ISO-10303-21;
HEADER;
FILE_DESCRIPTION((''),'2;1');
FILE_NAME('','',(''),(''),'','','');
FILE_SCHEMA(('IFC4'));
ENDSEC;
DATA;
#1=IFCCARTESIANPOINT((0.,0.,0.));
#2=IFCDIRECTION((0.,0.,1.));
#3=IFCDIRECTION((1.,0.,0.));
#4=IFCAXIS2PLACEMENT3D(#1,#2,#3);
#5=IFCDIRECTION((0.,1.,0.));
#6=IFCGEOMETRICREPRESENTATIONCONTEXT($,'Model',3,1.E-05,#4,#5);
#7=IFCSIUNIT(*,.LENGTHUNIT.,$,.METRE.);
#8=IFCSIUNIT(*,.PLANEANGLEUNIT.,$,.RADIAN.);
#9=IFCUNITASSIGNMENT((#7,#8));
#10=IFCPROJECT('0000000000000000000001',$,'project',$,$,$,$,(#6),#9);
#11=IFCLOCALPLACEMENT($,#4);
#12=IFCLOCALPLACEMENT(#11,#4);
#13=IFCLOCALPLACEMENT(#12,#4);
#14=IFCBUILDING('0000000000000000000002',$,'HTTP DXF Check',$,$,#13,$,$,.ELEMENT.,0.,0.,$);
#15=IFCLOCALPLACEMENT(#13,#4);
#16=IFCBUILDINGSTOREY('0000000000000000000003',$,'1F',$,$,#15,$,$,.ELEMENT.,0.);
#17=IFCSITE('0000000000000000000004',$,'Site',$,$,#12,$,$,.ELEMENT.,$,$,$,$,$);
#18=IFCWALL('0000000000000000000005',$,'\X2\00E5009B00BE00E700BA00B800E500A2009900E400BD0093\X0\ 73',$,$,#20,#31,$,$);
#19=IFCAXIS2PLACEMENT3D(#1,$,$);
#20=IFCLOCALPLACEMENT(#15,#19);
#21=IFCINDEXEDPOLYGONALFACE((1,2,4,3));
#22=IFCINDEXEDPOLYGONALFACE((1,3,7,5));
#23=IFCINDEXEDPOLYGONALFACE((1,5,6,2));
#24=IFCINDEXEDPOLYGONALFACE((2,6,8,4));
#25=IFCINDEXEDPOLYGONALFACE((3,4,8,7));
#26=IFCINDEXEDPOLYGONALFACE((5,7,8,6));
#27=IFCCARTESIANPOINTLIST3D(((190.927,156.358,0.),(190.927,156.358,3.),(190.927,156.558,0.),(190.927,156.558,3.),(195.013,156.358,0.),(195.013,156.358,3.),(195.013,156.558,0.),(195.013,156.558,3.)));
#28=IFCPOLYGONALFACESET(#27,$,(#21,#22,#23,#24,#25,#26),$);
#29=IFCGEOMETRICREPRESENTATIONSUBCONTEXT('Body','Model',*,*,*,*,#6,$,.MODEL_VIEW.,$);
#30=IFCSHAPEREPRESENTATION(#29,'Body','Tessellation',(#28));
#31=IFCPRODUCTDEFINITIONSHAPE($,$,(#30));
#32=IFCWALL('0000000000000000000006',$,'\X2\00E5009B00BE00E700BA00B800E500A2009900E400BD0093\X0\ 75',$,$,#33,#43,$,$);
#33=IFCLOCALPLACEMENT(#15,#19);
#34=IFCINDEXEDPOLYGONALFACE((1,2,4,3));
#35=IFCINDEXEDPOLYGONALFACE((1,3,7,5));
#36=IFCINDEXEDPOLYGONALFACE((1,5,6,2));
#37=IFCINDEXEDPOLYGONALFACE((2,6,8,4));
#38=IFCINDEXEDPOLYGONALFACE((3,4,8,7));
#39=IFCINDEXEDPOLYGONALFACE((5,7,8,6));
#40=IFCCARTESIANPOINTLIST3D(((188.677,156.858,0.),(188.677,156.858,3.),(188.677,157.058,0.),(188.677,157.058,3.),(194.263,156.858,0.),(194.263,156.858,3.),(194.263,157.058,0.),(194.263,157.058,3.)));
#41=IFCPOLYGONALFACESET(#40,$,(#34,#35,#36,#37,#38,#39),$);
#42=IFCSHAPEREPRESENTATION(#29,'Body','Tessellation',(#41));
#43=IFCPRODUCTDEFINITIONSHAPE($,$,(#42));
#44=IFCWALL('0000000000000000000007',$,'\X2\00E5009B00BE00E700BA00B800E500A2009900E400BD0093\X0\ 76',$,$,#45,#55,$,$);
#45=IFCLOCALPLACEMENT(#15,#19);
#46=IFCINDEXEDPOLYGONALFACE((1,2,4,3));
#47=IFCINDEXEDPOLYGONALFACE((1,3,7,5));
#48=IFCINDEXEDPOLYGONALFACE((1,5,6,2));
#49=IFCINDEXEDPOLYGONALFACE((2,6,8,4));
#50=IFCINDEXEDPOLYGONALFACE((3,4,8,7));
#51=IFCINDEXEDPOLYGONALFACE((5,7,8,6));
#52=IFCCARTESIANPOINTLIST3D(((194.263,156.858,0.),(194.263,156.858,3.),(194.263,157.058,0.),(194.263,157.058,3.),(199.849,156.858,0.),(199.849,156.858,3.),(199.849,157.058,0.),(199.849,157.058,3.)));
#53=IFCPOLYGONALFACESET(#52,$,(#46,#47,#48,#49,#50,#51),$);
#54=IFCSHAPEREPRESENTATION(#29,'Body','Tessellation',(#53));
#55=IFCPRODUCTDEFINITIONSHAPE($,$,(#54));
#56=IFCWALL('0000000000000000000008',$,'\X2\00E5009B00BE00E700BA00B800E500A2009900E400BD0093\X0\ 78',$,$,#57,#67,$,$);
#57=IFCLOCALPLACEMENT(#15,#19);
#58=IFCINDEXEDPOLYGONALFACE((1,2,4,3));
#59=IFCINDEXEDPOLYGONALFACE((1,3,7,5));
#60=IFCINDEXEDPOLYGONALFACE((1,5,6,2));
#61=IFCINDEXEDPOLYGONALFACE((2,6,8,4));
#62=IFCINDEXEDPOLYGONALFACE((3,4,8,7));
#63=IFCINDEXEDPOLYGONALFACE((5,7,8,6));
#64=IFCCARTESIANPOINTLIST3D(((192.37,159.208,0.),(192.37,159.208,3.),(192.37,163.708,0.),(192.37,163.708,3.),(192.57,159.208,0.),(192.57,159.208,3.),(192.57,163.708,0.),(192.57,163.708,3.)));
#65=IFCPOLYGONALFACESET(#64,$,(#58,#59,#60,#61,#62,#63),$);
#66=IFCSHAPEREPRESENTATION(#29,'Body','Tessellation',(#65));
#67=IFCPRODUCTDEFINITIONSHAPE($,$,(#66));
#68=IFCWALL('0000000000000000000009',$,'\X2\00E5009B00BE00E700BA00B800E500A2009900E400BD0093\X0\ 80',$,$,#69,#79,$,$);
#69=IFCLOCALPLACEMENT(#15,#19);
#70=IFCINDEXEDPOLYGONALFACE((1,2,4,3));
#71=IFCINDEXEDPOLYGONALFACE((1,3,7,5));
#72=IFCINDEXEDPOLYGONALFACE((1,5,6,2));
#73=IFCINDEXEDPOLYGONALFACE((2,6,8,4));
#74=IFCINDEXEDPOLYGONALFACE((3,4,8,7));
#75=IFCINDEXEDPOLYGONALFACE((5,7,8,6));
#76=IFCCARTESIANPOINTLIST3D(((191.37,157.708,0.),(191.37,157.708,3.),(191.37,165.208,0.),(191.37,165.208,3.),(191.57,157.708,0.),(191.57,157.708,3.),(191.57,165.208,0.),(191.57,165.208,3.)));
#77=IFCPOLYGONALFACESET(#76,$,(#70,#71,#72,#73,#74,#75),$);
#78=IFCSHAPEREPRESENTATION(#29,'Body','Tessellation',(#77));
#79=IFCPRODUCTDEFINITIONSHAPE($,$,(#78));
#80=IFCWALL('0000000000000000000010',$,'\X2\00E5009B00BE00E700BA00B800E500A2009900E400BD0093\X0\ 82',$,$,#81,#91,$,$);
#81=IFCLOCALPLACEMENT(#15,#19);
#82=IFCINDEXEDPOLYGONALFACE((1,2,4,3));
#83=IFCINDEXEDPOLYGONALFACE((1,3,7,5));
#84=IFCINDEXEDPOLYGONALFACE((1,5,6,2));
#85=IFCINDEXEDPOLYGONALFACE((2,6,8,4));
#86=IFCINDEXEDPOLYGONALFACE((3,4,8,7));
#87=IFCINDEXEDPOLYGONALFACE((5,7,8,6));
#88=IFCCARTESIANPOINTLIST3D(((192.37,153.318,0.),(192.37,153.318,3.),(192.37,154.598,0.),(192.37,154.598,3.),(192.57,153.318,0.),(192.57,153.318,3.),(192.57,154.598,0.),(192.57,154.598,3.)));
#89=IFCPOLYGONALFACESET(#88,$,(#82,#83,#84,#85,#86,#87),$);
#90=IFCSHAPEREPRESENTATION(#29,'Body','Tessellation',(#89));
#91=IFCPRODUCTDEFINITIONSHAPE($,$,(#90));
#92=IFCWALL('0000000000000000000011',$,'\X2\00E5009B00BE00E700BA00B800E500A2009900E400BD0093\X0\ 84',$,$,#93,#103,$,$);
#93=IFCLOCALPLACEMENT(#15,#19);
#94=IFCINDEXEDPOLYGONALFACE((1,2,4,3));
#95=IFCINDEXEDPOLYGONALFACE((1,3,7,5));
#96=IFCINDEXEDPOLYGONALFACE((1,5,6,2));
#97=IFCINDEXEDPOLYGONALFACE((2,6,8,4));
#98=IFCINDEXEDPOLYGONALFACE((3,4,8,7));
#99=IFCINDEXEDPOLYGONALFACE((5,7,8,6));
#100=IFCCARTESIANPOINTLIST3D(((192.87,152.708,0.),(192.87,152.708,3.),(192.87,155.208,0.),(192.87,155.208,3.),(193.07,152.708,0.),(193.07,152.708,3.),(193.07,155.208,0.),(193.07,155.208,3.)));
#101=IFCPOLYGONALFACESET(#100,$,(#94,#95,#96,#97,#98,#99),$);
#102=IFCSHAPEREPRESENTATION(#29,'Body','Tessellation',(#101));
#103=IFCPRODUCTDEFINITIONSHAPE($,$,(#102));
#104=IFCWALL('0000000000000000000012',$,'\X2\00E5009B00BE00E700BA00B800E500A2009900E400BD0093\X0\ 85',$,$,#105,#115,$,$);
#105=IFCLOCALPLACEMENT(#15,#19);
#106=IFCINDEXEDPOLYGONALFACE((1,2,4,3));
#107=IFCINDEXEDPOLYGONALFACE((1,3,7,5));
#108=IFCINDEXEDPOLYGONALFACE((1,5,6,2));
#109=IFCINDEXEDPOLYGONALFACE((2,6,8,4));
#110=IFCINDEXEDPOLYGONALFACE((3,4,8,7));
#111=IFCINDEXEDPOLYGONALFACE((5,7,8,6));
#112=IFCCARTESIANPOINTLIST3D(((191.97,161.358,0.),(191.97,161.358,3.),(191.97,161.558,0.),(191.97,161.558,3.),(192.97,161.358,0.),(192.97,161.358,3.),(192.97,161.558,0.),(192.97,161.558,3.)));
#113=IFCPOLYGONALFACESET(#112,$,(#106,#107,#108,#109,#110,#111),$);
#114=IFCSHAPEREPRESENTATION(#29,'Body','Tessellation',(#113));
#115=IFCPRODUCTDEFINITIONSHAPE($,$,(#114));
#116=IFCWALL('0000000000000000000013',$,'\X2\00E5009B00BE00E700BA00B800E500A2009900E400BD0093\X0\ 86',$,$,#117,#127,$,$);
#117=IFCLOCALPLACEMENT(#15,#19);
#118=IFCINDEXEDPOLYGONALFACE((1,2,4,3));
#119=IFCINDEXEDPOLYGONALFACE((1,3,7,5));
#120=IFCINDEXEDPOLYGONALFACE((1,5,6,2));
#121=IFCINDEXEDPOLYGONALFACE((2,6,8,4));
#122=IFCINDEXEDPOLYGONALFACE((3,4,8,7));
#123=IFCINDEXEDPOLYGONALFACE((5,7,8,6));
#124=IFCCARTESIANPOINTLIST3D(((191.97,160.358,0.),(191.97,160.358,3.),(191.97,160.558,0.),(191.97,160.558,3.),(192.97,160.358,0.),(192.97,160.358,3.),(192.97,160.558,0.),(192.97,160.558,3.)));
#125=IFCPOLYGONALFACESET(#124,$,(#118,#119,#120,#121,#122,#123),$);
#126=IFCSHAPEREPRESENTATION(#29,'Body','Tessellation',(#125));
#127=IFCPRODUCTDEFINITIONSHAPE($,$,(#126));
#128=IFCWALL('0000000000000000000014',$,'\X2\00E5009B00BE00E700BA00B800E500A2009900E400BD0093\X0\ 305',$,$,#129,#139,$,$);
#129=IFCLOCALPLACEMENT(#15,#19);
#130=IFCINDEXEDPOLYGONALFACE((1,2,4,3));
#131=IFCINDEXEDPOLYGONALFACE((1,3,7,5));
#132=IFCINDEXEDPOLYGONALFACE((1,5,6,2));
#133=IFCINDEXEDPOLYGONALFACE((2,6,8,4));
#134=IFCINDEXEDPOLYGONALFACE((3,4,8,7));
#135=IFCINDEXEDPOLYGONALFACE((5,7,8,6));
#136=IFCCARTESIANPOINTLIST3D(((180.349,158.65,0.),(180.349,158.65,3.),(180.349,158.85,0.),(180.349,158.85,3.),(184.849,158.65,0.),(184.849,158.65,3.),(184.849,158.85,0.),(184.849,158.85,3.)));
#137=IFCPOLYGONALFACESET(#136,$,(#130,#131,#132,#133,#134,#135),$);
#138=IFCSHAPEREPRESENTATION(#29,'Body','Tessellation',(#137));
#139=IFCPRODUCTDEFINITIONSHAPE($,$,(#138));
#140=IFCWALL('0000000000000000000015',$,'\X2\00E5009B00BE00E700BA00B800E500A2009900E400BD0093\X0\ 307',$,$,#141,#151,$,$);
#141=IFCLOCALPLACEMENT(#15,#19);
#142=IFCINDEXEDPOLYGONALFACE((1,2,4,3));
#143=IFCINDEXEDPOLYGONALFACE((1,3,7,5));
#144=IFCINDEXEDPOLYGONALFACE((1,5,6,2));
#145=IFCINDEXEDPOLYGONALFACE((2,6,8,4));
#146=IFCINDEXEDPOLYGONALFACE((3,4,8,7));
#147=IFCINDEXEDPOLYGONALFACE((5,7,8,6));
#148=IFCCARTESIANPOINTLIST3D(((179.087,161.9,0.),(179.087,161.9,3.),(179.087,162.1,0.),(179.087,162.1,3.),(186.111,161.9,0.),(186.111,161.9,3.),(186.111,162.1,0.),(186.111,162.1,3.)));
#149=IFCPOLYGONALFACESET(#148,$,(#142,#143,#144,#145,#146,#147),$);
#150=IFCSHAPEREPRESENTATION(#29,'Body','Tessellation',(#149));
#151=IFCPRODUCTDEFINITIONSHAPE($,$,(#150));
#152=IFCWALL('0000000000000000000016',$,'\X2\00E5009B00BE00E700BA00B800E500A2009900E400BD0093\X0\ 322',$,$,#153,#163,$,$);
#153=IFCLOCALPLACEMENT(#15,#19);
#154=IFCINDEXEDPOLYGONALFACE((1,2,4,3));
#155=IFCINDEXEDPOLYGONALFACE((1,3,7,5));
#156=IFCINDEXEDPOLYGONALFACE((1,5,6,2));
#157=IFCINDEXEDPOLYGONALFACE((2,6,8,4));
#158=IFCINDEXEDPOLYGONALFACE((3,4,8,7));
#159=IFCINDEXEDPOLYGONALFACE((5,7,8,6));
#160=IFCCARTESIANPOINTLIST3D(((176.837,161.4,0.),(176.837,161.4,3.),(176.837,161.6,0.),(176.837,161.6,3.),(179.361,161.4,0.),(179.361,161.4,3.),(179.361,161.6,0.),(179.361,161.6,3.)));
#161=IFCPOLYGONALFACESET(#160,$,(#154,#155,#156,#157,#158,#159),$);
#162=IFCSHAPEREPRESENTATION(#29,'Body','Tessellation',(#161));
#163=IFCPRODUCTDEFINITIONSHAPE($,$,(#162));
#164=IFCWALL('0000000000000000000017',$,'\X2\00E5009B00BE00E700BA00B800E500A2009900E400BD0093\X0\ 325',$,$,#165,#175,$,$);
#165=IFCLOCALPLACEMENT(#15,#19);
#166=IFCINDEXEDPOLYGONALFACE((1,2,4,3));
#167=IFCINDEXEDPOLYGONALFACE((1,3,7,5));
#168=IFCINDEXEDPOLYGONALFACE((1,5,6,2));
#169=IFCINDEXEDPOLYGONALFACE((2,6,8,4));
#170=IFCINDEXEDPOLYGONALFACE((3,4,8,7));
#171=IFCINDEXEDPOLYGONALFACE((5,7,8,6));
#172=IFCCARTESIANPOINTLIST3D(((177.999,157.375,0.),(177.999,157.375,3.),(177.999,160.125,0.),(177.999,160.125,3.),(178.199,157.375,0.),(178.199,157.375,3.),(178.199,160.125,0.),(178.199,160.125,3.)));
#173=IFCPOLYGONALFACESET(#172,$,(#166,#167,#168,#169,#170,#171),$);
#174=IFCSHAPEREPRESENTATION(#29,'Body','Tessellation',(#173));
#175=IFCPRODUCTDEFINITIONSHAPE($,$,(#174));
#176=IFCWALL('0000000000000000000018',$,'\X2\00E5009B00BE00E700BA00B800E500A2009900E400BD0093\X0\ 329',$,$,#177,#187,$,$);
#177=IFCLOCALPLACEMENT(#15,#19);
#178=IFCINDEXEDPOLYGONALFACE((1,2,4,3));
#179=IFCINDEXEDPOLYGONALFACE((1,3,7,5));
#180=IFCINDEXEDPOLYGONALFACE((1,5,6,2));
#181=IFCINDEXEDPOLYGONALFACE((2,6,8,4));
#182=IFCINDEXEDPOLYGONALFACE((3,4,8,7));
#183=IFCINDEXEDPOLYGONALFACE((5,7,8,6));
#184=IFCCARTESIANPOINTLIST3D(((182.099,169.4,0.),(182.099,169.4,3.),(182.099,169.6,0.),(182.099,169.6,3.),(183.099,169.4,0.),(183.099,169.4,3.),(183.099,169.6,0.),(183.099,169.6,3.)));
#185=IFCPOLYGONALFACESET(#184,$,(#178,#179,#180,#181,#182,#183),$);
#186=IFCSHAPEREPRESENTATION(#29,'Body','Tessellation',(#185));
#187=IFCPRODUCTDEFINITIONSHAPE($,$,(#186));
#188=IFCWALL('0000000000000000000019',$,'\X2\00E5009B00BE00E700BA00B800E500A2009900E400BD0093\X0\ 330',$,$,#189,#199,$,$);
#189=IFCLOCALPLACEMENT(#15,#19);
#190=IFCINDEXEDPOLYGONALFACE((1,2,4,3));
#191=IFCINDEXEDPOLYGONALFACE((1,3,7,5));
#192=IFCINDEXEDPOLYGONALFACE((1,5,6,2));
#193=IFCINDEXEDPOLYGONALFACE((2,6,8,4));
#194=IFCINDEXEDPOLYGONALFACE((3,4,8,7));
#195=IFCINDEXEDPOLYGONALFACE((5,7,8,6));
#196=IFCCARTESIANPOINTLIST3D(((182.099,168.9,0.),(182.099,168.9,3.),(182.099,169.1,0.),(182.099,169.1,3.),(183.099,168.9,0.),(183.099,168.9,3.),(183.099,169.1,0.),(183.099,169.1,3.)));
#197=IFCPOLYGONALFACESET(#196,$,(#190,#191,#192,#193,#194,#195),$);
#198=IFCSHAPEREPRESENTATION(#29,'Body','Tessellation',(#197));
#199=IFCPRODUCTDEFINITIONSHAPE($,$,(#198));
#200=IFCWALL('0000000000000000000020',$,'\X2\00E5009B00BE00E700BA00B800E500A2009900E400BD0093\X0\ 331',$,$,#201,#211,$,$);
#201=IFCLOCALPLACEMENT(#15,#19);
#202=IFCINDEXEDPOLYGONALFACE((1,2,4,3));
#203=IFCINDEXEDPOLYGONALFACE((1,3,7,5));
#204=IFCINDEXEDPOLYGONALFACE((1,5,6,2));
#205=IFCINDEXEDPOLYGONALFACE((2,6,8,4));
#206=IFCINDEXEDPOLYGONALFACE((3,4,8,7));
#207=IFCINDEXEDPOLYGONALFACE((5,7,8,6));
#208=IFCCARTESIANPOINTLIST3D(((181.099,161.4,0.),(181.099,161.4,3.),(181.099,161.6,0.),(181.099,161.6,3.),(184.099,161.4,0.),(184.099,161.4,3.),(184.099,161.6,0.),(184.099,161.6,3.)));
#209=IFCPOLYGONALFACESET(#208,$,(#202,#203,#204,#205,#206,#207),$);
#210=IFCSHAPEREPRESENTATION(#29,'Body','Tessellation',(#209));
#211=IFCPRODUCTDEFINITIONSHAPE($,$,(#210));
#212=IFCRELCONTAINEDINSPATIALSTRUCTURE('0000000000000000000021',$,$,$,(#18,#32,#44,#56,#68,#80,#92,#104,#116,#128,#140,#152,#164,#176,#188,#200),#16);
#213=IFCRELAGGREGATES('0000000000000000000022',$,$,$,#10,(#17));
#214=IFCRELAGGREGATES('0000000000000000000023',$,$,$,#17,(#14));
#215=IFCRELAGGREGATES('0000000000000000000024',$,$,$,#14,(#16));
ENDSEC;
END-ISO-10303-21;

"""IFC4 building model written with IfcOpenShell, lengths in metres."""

from ifc_helpers import new_model, si_unit, direction, frame, frame_2d, origin_with_axes, place, context, subcontext, project, spatial, rectangle, extrude, element, save


model = new_model("IFC4")

# Units and contexts
model_context = context("Model", 3, precision=1e-05, world=origin_with_axes(), true_north=direction((0.0, 1.0, 0.0)))
body_context = subcontext(model_context, "Body", "Model", "MODEL_VIEW")
ifc_project = project(units=[si_unit("LENGTHUNIT", "METRE"), si_unit("PLANEANGLEUNIT", "RADIAN")], contexts=[model_context])

# Site, building, storey
placement = place(None, origin_with_axes())
site_placement = place(placement, origin_with_axes())
site = spatial("IfcSite", under=ifc_project, at=site_placement, Name="Site", CompositionType="ELEMENT")
building_placement = place(site_placement, origin_with_axes())
building = spatial("IfcBuilding", under=site, at=building_placement, Name="HTTP DXF Check", CompositionType="ELEMENT", ElevationOfRefHeight=0.0, ElevationOfTerrain=0.0)
storey_placement = place(building_placement, origin_with_axes())
storey = spatial("IfcBuildingStorey", under=building, at=storey_placement, Name="1F", CompositionType="ELEMENT", Elevation=0.0)

# Walls
for number, where, z_axis, x_axis, name in (
    (1, (192.97, 156.458, 0.0), (0.0, 0.0, 1.0), (1.0, 0.0, 0.0), "å\u009b¾çº¸å¢\u0099ä½\u0093 73"),
):
    element("IfcWall", number, at=place(storey_placement, frame(where, z_axis=z_axis, x_axis=x_axis)), inside=storey, Name=name, context=body_context, shape_type="SweptSolid", body=[
        extrude(rectangle(XDim=4.086, YDim=0.2, at=frame_2d((0.0, 0.0), x_axis=(1.0, 0.0, 0.0))), frame((0.0, 0.0, 0.0), z_axis=(0.0, 0.0, 1.0)), (0.0, 0.0, 1.0), 3.0),
    ])
for number, where, z_axis, x_axis, name in (
    (2, (191.47, 156.958, 0.0), (0.0, 0.0, 1.0), (1.0, 0.0, 0.0), "å\u009b¾çº¸å¢\u0099ä½\u0093 75"),
    (3, (197.056, 156.958, 0.0), (0.0, 0.0, 1.0), (-1.0, 0.0, 0.0), "å\u009b¾çº¸å¢\u0099ä½\u0093 76"),
):
    element("IfcWall", number, at=place(storey_placement, frame(where, z_axis=z_axis, x_axis=x_axis)), inside=storey, Name=name, context=body_context, shape_type="SweptSolid", body=[
        extrude(rectangle(XDim=5.586, YDim=0.2, at=frame_2d((0.0, 0.0), x_axis=(1.0, 0.0, 0.0))), frame((0.0, 0.0, 0.0), z_axis=(0.0, 0.0, 1.0)), (0.0, 0.0, 1.0), 3.0),
    ])
wall_1_placement = place(storey_placement, frame((192.47, 161.458, 0.0), z_axis=(0.0, 0.0, 1.0), x_axis=(0.0, -1.0, 0.0)))
element("IfcWall", 4, at=wall_1_placement, inside=storey, Name="å\u009b¾çº¸å¢\u0099ä½\u0093 78", context=body_context, shape_type="SweptSolid", body=[
    extrude(rectangle(XDim=4.5, YDim=0.2, at=frame_2d((0.0, 0.0), x_axis=(1.0, 0.0, 0.0))), frame((0.0, 0.0, 0.0), z_axis=(0.0, 0.0, 1.0)), (0.0, 0.0, 1.0), 3.0),
])
wall_2_placement = place(storey_placement, frame((191.47, 161.458, 0.0), z_axis=(0.0, 0.0, 1.0), x_axis=(0.0, -1.0, 0.0)))
element("IfcWall", 5, at=wall_2_placement, inside=storey, Name="å\u009b¾çº¸å¢\u0099ä½\u0093 80", context=body_context, shape_type="SweptSolid", body=[
    extrude(rectangle(XDim=7.5, YDim=0.2, at=frame_2d((0.0, 0.0), x_axis=(1.0, 0.0, 0.0))), frame((0.0, 0.0, 0.0), z_axis=(0.0, 0.0, 1.0)), (0.0, 0.0, 1.0), 3.0),
])
wall_3_placement = place(storey_placement, frame((192.47, 153.958, 0.0), z_axis=(0.0, 0.0, 1.0), x_axis=(0.0, -1.0, 0.0)))
element("IfcWall", 6, at=wall_3_placement, inside=storey, Name="å\u009b¾çº¸å¢\u0099ä½\u0093 82", context=body_context, shape_type="SweptSolid", body=[
    extrude(rectangle(XDim=1.28, YDim=0.2, at=frame_2d((0.0, 0.0), x_axis=(1.0, 0.0, 0.0))), frame((0.0, 0.0, 0.0), z_axis=(0.0, 0.0, 1.0)), (0.0, 0.0, 1.0), 3.0),
])
wall_4_placement = place(storey_placement, frame((192.97, 153.958, 0.0), z_axis=(0.0, 0.0, 1.0), x_axis=(0.0, 1.0, 0.0)))
element("IfcWall", 7, at=wall_4_placement, inside=storey, Name="å\u009b¾çº¸å¢\u0099ä½\u0093 84", context=body_context, shape_type="SweptSolid", body=[
    extrude(rectangle(XDim=2.5, YDim=0.2, at=frame_2d((0.0, 0.0), x_axis=(1.0, 0.0, 0.0))), frame((0.0, 0.0, 0.0), z_axis=(0.0, 0.0, 1.0)), (0.0, 0.0, 1.0), 3.0),
])
for number, where, z_axis, x_axis, name in (
    (8, (192.47, 161.458, 0.0), (0.0, 0.0, 1.0), (-1.0, 0.0, 0.0), "å\u009b¾çº¸å¢\u0099ä½\u0093 85"),
    (9, (192.47, 160.458, 0.0), (0.0, 0.0, 1.0), (-1.0, 0.0, 0.0), "å\u009b¾çº¸å¢\u0099ä½\u0093 86"),
):
    element("IfcWall", number, at=place(storey_placement, frame(where, z_axis=z_axis, x_axis=x_axis)), inside=storey, Name=name, context=body_context, shape_type="SweptSolid", body=[
        extrude(rectangle(XDim=1.0, YDim=0.2, at=frame_2d((0.0, 0.0), x_axis=(1.0, 0.0, 0.0))), frame((0.0, 0.0, 0.0), z_axis=(0.0, 0.0, 1.0)), (0.0, 0.0, 1.0), 3.0),
    ])
wall_5_placement = place(storey_placement, frame((182.599, 158.75, 0.0), z_axis=(0.0, 0.0, 1.0), x_axis=(-1.0, 0.0, 0.0)))
element("IfcWall", 10, at=wall_5_placement, inside=storey, Name="å\u009b¾çº¸å¢\u0099ä½\u0093 305", context=body_context, shape_type="SweptSolid", body=[
    extrude(rectangle(XDim=4.5, YDim=0.2, at=frame_2d((0.0, 0.0), x_axis=(1.0, 0.0, 0.0))), frame((0.0, 0.0, 0.0), z_axis=(0.0, 0.0, 1.0)), (0.0, 0.0, 1.0), 3.0),
])
wall_6_placement = place(storey_placement, frame((182.599, 162.0, 0.0), z_axis=(0.0, 0.0, 1.0), x_axis=(-1.0, 0.0, 0.0)))
element("IfcWall", 11, at=wall_6_placement, inside=storey, Name="å\u009b¾çº¸å¢\u0099ä½\u0093 307", context=body_context, shape_type="SweptSolid", body=[
    extrude(rectangle(XDim=7.024, YDim=0.2, at=frame_2d((0.0, 0.0), x_axis=(1.0, 0.0, 0.0))), frame((0.0, 0.0, 0.0), z_axis=(0.0, 0.0, 1.0)), (0.0, 0.0, 1.0), 3.0),
])
wall_7_placement = place(storey_placement, frame((178.099, 161.5, 0.0), z_axis=(0.0, 0.0, 1.0), x_axis=(-1.0, 0.0, 0.0)))
element("IfcWall", 12, at=wall_7_placement, inside=storey, Name="å\u009b¾çº¸å¢\u0099ä½\u0093 322", context=body_context, shape_type="SweptSolid", body=[
    extrude(rectangle(XDim=2.524, YDim=0.2, at=frame_2d((0.0, 0.0), x_axis=(1.0, 0.0, 0.0))), frame((0.0, 0.0, 0.0), z_axis=(0.0, 0.0, 1.0)), (0.0, 0.0, 1.0), 3.0),
])
wall_8_placement = place(storey_placement, frame((178.099, 158.75, 0.0), z_axis=(0.0, 0.0, 1.0), x_axis=(0.0, 1.0, 0.0)))
element("IfcWall", 13, at=wall_8_placement, inside=storey, Name="å\u009b¾çº¸å¢\u0099ä½\u0093 325", context=body_context, shape_type="SweptSolid", body=[
    extrude(rectangle(XDim=2.75, YDim=0.2, at=frame_2d((0.0, 0.0), x_axis=(1.0, 0.0, 0.0))), frame((0.0, 0.0, 0.0), z_axis=(0.0, 0.0, 1.0)), (0.0, 0.0, 1.0), 3.0),
])
for number, where, z_axis, x_axis, name in (
    (14, (182.599, 169.5, 0.0), (0.0, 0.0, 1.0), (-1.0, 0.0, 0.0), "å\u009b¾çº¸å¢\u0099ä½\u0093 329"),
    (15, (182.599, 169.0, 0.0), (0.0, 0.0, 1.0), (-1.0, 0.0, 0.0), "å\u009b¾çº¸å¢\u0099ä½\u0093 330"),
):
    element("IfcWall", number, at=place(storey_placement, frame(where, z_axis=z_axis, x_axis=x_axis)), inside=storey, Name=name, context=body_context, shape_type="SweptSolid", body=[
        extrude(rectangle(XDim=1.0, YDim=0.2, at=frame_2d((0.0, 0.0), x_axis=(1.0, 0.0, 0.0))), frame((0.0, 0.0, 0.0), z_axis=(0.0, 0.0, 1.0)), (0.0, 0.0, 1.0), 3.0),
    ])
wall_9_placement = place(storey_placement, frame((182.599, 161.5, 0.0), z_axis=(0.0, 0.0, 1.0), x_axis=(-1.0, 0.0, 0.0)))
element("IfcWall", 16, at=wall_9_placement, inside=storey, Name="å\u009b¾çº¸å¢\u0099ä½\u0093 331", context=body_context, shape_type="SweptSolid", body=[
    extrude(rectangle(XDim=3.0, YDim=0.2, at=frame_2d((0.0, 0.0), x_axis=(1.0, 0.0, 0.0))), frame((0.0, 0.0, 0.0), z_axis=(0.0, 0.0, 1.0)), (0.0, 0.0, 1.0), 3.0),
])

save(model, "model.ifc")
